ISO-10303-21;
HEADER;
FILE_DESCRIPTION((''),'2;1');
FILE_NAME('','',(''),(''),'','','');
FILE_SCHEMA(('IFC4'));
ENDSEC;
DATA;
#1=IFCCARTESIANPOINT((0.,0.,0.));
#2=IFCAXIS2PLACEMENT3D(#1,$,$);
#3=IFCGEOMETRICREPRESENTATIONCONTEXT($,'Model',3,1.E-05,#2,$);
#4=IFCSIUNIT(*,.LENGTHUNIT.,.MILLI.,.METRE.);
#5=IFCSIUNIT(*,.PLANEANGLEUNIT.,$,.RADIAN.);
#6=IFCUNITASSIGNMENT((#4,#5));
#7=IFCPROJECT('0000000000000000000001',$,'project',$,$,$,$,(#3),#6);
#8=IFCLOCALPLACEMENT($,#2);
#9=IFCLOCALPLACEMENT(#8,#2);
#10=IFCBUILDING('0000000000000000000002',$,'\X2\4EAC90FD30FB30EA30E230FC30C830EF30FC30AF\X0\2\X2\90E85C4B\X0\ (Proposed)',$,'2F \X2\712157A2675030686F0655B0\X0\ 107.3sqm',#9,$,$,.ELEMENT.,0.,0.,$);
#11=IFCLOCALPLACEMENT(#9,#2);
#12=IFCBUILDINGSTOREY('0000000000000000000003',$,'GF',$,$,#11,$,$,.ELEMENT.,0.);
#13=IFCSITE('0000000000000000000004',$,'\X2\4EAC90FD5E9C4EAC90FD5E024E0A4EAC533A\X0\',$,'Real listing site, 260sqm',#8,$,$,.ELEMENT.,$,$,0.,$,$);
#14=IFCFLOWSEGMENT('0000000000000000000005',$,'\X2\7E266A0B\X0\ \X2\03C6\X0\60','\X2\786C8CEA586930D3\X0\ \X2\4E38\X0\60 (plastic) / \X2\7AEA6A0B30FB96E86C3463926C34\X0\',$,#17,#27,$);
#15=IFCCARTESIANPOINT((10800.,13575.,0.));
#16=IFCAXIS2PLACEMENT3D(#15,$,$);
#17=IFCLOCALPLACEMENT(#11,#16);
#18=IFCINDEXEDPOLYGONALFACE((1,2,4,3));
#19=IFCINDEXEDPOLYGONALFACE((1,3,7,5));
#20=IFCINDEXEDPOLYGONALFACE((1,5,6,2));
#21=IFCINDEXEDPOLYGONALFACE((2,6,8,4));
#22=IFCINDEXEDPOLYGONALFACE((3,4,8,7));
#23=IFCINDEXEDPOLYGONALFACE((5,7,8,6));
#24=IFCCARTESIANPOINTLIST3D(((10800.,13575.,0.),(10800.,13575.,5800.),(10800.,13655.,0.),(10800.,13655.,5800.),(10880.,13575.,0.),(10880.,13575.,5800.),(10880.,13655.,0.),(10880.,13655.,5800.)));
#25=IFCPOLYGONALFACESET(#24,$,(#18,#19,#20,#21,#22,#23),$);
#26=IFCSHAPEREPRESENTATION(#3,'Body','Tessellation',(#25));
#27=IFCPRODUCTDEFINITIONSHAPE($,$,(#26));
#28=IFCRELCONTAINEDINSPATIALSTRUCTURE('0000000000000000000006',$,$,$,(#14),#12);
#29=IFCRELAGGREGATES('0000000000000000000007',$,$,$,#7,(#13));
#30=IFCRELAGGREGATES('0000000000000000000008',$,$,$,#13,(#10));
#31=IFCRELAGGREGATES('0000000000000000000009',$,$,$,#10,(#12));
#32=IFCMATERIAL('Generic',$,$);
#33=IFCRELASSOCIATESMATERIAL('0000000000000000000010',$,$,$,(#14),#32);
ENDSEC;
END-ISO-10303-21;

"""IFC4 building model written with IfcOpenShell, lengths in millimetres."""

from ifc_helpers import new_model, si_unit, frame, frame_2d, origin, place, context, project, spatial, rectangle, extrude, material, element, save


model = new_model("IFC4")

# Units and contexts
model_context = context("Model", 3, precision=1e-05, world=origin())
ifc_project = project(units=[si_unit("LENGTHUNIT", "METRE", prefix="MILLI"), si_unit("PLANEANGLEUNIT", "RADIAN")], contexts=[model_context])

# Site, building, storey
site_placement = place(None, origin())
site = spatial("IfcSite", under=ifc_project, at=site_placement, Name="京都府京都市上京区", ObjectType="Real listing site, 260sqm", CompositionType="ELEMENT", RefElevation=0.0)
building_placement = place(site_placement, origin())
building = spatial("IfcBuilding", under=site, at=building_placement, Name="京都・リモートワーク2部屋 (Proposed)", ObjectType="2F 無垢材と漆喰 107.3sqm", CompositionType="ELEMENT", ElevationOfRefHeight=0.0, ElevationOfTerrain=0.0)
storey_placement = place(building_placement, origin())
storey = spatial("IfcBuildingStorey", under=building, at=storey_placement, Name="GF", CompositionType="ELEMENT", Elevation=0.0)

# Flow segment
ifc_material_1 = material(Name="Generic")
flow_segment_placement = place(storey_placement, frame((10800.0, 13575.0, 0.0)))
element("IfcFlowSegment", 1, at=flow_segment_placement, inside=storey, material=ifc_material_1, Name="縦樋 φ60", Description="硬質塩ビ 丸60 (plastic) / 竪樋・雨水排水", context=model_context, shape_type="SweptSolid", body=[
    extrude(rectangle(XDim=80.0, YDim=80.0, at=frame_2d((40.0, 40.0))), frame((10800.0, 13575.0, 0.0)), (0.0, 0.0, 1.0), 5800.0),
])

save(model, "model.ifc")
